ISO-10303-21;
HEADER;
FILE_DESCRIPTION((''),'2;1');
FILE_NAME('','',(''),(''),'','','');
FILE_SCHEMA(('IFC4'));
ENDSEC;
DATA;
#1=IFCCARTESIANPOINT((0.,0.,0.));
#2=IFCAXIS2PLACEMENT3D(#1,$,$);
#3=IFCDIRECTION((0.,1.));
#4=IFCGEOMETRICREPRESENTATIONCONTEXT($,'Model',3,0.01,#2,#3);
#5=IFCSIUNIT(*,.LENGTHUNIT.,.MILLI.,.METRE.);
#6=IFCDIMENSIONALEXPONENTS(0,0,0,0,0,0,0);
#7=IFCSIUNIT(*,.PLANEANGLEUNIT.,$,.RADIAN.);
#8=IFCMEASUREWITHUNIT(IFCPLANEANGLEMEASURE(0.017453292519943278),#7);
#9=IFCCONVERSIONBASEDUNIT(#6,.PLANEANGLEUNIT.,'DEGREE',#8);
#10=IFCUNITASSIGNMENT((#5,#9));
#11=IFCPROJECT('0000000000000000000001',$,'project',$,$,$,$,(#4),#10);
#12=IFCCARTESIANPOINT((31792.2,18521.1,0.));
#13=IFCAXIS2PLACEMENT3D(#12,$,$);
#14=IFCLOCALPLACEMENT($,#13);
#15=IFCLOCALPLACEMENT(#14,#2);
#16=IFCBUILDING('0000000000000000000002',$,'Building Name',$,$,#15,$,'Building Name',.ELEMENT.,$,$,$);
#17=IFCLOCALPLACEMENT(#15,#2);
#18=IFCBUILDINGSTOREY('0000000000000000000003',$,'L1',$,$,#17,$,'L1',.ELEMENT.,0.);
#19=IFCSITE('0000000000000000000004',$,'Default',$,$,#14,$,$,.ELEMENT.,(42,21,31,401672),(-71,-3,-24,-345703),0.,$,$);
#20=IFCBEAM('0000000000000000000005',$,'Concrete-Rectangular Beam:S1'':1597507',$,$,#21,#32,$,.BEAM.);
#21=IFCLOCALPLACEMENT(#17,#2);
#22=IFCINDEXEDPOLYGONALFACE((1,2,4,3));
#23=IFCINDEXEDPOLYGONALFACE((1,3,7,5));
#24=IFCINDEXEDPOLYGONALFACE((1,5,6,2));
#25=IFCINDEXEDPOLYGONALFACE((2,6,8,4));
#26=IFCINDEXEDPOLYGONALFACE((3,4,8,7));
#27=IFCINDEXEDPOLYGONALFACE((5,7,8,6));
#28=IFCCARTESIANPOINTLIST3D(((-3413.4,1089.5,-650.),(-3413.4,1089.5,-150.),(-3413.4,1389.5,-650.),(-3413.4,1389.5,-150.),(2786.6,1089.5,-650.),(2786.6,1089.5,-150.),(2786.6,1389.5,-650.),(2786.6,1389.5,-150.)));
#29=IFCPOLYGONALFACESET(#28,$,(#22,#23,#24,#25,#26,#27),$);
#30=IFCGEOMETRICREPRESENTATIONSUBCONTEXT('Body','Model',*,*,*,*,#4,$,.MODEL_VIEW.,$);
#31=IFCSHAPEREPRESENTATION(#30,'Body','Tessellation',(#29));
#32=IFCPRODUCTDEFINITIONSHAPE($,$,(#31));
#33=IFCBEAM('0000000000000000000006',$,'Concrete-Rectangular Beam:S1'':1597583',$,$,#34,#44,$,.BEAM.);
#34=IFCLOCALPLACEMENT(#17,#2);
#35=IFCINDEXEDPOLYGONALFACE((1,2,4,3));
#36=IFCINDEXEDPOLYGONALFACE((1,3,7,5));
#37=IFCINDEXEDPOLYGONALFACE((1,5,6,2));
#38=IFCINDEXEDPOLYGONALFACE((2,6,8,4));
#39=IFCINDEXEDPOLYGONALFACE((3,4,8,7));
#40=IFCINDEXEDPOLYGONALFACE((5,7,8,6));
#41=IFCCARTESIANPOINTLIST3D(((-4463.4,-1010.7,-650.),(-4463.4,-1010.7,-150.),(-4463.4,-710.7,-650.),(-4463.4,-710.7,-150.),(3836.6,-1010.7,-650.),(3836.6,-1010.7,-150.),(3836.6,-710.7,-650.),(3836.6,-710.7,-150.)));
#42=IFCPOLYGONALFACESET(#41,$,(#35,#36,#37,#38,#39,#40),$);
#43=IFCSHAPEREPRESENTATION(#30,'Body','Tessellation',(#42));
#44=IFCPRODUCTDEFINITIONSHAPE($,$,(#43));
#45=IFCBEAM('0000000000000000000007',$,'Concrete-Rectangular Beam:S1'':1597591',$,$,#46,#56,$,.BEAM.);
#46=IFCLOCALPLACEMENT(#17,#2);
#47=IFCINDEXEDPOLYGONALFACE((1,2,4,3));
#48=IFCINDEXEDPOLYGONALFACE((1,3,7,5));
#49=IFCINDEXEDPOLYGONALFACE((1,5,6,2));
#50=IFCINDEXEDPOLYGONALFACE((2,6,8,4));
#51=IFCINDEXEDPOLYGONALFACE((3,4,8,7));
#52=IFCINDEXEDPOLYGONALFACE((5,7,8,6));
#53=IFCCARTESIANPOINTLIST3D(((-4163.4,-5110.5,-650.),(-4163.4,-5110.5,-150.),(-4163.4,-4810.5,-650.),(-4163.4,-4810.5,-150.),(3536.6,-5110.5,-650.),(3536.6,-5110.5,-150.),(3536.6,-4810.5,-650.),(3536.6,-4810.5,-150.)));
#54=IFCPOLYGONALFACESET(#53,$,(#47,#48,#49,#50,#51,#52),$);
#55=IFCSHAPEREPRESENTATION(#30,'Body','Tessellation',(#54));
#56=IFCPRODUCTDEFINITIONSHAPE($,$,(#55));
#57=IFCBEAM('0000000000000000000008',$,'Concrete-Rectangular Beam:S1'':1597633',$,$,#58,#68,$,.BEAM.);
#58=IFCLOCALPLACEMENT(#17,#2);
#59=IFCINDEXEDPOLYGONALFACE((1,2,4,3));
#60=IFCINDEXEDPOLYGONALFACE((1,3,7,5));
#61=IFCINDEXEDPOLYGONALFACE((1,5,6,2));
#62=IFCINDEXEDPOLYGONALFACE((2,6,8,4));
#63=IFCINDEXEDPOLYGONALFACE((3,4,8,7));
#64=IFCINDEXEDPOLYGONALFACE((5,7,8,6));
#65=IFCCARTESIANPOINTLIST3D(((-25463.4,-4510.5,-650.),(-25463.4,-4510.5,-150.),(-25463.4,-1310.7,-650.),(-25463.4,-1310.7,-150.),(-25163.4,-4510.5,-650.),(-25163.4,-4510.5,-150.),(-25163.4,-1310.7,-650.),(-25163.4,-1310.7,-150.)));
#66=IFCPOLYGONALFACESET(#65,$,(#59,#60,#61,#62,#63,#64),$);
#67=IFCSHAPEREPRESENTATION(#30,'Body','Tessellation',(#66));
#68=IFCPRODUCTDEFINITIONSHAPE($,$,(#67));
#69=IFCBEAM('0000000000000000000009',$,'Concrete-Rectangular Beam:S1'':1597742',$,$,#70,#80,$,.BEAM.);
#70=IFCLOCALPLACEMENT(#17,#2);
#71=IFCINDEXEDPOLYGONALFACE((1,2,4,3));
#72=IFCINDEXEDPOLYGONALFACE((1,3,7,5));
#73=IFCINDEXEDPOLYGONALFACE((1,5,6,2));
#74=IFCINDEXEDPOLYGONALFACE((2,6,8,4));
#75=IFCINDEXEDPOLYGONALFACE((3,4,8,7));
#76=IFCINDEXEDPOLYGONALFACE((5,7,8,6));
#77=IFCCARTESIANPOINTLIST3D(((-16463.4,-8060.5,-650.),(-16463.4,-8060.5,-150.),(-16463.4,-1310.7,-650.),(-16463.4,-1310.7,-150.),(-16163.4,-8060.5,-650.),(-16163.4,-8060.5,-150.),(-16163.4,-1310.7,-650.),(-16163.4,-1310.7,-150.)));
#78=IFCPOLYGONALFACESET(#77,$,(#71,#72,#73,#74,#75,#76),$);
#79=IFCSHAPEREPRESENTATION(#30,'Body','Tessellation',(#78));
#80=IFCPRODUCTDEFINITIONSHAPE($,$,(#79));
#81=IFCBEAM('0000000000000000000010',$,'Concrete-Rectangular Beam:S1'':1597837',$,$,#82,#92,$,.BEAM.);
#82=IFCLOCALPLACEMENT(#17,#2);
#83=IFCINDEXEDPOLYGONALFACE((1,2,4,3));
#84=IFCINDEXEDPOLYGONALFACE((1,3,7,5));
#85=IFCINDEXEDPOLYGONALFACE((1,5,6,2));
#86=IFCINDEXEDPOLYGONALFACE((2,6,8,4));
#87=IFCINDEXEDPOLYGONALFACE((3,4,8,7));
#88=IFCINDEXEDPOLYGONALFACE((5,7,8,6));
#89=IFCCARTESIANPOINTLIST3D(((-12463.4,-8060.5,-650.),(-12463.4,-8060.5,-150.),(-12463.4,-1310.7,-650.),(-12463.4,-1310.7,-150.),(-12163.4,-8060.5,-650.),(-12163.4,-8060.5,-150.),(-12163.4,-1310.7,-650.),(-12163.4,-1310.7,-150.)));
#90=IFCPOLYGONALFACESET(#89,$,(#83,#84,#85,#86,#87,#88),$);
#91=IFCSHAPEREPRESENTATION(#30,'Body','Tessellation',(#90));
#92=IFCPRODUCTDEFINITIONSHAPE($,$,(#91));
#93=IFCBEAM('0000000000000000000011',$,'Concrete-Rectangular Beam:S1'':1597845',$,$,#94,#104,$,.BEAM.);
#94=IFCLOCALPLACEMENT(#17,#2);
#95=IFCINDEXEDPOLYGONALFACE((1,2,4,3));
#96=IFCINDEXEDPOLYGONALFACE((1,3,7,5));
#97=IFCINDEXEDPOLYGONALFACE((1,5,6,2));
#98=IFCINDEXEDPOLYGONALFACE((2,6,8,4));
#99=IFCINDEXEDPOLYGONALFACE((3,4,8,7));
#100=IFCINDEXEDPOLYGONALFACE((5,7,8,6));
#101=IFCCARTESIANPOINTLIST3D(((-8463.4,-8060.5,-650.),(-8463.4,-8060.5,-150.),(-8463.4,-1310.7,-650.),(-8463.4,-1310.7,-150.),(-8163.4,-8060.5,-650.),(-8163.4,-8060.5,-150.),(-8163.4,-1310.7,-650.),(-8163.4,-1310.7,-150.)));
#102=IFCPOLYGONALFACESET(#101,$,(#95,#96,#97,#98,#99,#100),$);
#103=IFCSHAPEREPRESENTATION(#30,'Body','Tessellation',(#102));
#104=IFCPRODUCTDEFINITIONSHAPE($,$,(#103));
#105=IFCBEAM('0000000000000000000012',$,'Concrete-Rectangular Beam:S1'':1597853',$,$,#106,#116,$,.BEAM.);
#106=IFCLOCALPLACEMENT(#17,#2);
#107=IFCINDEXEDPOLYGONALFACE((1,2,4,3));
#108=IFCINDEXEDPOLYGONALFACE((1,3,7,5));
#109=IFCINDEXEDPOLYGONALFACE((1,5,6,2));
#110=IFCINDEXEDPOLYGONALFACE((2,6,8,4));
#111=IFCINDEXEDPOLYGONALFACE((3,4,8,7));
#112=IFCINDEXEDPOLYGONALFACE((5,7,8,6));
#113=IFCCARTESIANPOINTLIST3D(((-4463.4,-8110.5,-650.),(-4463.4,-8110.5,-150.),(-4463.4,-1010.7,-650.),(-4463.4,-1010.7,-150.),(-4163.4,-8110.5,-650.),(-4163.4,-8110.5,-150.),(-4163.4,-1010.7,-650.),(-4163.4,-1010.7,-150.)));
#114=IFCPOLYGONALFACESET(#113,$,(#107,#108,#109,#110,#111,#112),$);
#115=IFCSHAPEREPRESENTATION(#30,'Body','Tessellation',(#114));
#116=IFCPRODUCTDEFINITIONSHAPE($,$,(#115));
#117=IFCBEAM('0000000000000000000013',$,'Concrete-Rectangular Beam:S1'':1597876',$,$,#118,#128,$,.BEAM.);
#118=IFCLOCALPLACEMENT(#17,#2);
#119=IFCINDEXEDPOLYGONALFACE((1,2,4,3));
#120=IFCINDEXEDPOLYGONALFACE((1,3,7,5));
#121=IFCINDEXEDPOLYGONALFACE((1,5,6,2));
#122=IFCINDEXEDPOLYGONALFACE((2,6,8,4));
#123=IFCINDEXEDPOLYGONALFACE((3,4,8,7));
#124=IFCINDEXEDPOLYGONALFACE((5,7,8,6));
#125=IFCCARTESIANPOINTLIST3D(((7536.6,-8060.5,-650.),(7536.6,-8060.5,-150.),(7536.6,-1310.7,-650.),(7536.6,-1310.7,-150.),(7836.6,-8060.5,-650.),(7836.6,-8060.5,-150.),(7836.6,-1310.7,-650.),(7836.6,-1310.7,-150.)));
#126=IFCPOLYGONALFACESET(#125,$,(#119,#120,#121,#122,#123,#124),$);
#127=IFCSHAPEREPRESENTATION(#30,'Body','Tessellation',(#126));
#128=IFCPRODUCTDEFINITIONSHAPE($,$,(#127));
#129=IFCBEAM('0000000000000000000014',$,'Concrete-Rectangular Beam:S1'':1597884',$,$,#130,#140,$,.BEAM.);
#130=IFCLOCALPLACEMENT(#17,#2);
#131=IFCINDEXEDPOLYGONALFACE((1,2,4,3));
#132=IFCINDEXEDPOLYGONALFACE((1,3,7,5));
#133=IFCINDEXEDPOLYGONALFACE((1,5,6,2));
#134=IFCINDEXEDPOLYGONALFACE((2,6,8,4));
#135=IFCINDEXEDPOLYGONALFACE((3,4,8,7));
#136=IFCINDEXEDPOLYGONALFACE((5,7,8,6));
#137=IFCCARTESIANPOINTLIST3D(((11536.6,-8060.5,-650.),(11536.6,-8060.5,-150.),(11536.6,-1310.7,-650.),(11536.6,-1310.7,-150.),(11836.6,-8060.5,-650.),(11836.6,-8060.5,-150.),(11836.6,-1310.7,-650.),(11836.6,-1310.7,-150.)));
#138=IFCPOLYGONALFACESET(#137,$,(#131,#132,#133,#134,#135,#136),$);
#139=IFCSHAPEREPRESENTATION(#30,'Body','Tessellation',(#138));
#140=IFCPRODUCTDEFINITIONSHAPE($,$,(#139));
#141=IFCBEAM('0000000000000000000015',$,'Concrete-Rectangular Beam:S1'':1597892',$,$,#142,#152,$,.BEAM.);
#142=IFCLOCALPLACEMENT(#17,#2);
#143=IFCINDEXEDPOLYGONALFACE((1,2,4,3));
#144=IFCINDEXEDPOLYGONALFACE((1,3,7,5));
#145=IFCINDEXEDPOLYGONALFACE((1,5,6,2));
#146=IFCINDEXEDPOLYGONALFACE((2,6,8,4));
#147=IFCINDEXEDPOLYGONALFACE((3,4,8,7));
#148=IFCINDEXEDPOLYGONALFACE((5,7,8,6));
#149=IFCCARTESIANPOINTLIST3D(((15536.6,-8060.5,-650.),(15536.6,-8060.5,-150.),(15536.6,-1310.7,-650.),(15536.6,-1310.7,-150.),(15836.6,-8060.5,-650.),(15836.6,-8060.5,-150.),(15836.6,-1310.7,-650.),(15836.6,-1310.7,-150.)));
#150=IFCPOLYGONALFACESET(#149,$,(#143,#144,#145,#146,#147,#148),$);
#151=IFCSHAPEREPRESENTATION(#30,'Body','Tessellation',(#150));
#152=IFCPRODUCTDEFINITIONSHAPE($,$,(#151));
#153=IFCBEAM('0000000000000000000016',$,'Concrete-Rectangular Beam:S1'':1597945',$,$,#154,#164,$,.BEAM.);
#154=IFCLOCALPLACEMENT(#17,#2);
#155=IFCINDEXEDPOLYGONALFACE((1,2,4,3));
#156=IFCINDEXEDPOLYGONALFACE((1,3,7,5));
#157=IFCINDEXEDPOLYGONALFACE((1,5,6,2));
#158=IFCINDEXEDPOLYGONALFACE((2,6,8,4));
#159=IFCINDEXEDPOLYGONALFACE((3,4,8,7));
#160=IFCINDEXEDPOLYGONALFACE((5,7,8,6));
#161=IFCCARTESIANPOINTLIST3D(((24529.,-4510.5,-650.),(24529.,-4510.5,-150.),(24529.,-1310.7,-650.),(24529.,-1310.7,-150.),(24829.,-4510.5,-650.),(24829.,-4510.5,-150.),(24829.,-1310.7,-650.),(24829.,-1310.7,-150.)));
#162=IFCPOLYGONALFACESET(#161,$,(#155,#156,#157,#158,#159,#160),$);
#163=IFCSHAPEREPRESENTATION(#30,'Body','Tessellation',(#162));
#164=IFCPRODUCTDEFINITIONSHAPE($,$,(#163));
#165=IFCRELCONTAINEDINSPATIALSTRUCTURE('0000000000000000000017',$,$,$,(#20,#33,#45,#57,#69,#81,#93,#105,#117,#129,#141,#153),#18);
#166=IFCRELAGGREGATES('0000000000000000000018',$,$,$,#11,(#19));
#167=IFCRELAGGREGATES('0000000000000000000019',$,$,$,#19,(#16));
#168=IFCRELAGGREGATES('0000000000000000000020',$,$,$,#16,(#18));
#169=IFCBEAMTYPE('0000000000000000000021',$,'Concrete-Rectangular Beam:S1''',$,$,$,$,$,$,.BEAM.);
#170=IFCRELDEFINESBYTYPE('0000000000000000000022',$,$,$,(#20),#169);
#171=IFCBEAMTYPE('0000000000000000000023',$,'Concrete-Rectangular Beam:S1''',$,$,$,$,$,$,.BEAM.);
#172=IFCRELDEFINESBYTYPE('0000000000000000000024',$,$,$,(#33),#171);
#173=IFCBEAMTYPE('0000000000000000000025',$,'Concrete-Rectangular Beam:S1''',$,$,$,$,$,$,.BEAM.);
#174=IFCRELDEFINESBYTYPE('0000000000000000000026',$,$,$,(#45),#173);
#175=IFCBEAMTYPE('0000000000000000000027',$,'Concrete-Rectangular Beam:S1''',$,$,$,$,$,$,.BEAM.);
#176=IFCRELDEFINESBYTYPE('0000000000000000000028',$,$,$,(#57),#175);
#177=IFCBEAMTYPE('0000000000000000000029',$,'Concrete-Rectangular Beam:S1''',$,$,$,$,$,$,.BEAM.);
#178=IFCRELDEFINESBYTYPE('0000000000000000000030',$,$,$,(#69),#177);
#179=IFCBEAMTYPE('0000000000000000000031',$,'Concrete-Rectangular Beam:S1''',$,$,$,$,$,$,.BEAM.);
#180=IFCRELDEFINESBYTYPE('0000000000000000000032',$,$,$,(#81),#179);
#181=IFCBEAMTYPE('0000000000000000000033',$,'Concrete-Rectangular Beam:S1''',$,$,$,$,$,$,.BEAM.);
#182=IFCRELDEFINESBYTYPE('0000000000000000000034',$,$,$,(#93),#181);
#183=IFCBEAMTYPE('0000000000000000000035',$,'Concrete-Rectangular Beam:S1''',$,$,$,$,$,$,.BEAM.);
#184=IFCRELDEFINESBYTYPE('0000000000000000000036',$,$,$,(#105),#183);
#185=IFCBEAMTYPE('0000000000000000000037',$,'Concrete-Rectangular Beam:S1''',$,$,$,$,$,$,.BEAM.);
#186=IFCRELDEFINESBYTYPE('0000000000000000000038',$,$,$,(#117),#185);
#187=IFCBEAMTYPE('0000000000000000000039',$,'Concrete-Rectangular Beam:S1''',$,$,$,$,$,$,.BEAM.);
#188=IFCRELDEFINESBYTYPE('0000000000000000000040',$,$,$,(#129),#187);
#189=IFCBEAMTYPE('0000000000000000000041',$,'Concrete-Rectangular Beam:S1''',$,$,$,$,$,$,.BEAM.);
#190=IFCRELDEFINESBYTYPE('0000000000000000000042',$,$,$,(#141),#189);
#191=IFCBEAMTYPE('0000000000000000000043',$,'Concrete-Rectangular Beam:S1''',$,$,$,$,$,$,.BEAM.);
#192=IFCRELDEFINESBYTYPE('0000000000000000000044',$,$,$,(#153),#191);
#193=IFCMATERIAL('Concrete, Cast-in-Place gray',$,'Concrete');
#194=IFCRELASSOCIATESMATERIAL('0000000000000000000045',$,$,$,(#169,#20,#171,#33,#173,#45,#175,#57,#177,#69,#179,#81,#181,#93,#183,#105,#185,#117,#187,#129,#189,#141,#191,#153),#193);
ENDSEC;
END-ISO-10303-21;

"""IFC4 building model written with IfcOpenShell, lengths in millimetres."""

from ifc_helpers import new_model, entity, si_unit, converted_unit, direction, frame, origin, place, context, subcontext, project, spatial, indexed_curve, outline, extrude, source, transform, mapped, material, type_object, type_shapes, element, save


model = new_model("IFC4")

# Units and contexts
model_context = context("Model", 3, precision=0.01, world=origin(), true_north=direction((0.0, 1.0)))
body_context = subcontext(model_context, "Body", "Model", "MODEL_VIEW")
ifc_project = project(units=[si_unit("LENGTHUNIT", "METRE", prefix="MILLI"), converted_unit("PLANEANGLEUNIT", "DEGREE", entity("IfcPlaneAngleMeasure", 0.017453292519943278), si_unit("PLANEANGLEUNIT", "RADIAN"), dimensions=[0, 0, 0, 0, 0, 0, 0])], contexts=[model_context])

# Site, building, storey
site_placement = place(None, frame((31792.2, 18521.1, 0.0)))
site = spatial("IfcSite", under=ifc_project, at=site_placement, Name="Default", CompositionType="ELEMENT", RefLatitude=(42, 21, 31, 401672), RefLongitude=(-71, -3, -24, -345703), RefElevation=0.0)
building_placement = place(site_placement, origin())
building = spatial("IfcBuilding", under=site, at=building_placement, Name="Building Name", LongName="Building Name", CompositionType="ELEMENT")
storey_placement = place(building_placement, origin())
storey = spatial("IfcBuildingStorey", under=building, at=storey_placement, Name="L1", LongName="L1", CompositionType="ELEMENT", Elevation=0.0)

# Beams
ifc_material = material(Name="Concrete, Cast-in-Place gray", Category="Concrete")
beam_type_1 = type_object("IfcBeamType", Name="Concrete-Rectangular Beam:S1'", PredefinedType="BEAM", material=ifc_material)
shared_shape_1 = source(origin(), body_context, "Body", "SweptSolid", [
    extrude(outline(indexed_curve([(-250.0, -150.0), (250.0, -150.0), (250.0, 150.0), (-250.0, 150.0), (-250.0, -150.0)], self_intersect=False)), frame((-3413.4, 1239.5, -400.0), z_axis=(1.0, 0.0, 0.0), x_axis=(0.0, 0.0, -1.0)), (0.0, 0.0, 1.0), 6200.0),
])
type_shapes(beam_type_1, [shared_shape_1])
beam_1_placement = place(storey_placement, origin())
element("IfcBeam", 1, at=beam_1_placement, inside=storey, type_object=beam_type_1, material=ifc_material, Name="Concrete-Rectangular Beam:S1':1597507", PredefinedType="BEAM", context=body_context, shape_type="MappedRepresentation", body=[
    mapped(shared_shape_1, transform((0.0, 0.0, 0.0), scale=1.0)),
])
beam_type_2 = type_object("IfcBeamType", Name="Concrete-Rectangular Beam:S1'", PredefinedType="BEAM", material=ifc_material)
shared_shape_2 = source(origin(), body_context, "Body", "SweptSolid", [
    extrude(outline(indexed_curve([(-250.0, -150.0), (250.0, -150.0), (250.0, 150.0), (-250.0, 150.0), (-250.0, -150.0)], self_intersect=False)), frame((-4463.4, -860.7, -400.0), z_axis=(1.0, 0.0, 0.0), x_axis=(0.0, 0.0, -1.0)), (0.0, 0.0, 1.0), 8300.0),
])
type_shapes(beam_type_2, [shared_shape_2])
beam_2_placement = place(storey_placement, origin())
element("IfcBeam", 2, at=beam_2_placement, inside=storey, type_object=beam_type_2, material=ifc_material, Name="Concrete-Rectangular Beam:S1':1597583", PredefinedType="BEAM", context=body_context, shape_type="MappedRepresentation", body=[
    mapped(shared_shape_2, transform((0.0, 0.0, 0.0), scale=1.0)),
])
beam_type_3 = type_object("IfcBeamType", Name="Concrete-Rectangular Beam:S1'", PredefinedType="BEAM", material=ifc_material)
shared_shape_3 = source(origin(), body_context, "Body", "SweptSolid", [
    extrude(outline(indexed_curve([(-250.0, -150.0), (250.0, -150.0), (250.0, 150.0), (-250.0, 150.0), (-250.0, -150.0)], self_intersect=False)), frame((-4163.4, -4960.5, -400.0), z_axis=(1.0, 0.0, 0.0), x_axis=(0.0, 0.0, -1.0)), (0.0, 0.0, 1.0), 7700.0),
])
type_shapes(beam_type_3, [shared_shape_3])
beam_3_placement = place(storey_placement, origin())
element("IfcBeam", 3, at=beam_3_placement, inside=storey, type_object=beam_type_3, material=ifc_material, Name="Concrete-Rectangular Beam:S1':1597591", PredefinedType="BEAM", context=body_context, shape_type="MappedRepresentation", body=[
    mapped(shared_shape_3, transform((0.0, 0.0, 0.0), scale=1.0)),
])
beam_type_4 = type_object("IfcBeamType", Name="Concrete-Rectangular Beam:S1'", PredefinedType="BEAM", material=ifc_material)
shared_shape_4 = source(origin(), body_context, "Body", "SweptSolid", [
    extrude(outline(indexed_curve([(-150.0, -250.0), (150.0, -250.0), (150.0, 250.0), (-150.0, 250.0), (-150.0, -250.0)], self_intersect=False)), frame((-25313.4, -4510.5, -400.0), z_axis=(0.0, 1.0, 0.0), x_axis=(-1.0, 0.0, 0.0)), (0.0, 0.0, 1.0), 3199.8),
])
type_shapes(beam_type_4, [shared_shape_4])
beam_4_placement = place(storey_placement, origin())
element("IfcBeam", 4, at=beam_4_placement, inside=storey, type_object=beam_type_4, material=ifc_material, Name="Concrete-Rectangular Beam:S1':1597633", PredefinedType="BEAM", context=body_context, shape_type="MappedRepresentation", body=[
    mapped(shared_shape_4, transform((0.0, 0.0, 0.0), scale=1.0)),
])
beam_type_5 = type_object("IfcBeamType", Name="Concrete-Rectangular Beam:S1'", PredefinedType="BEAM", material=ifc_material)
shared_shape_5 = source(origin(), body_context, "Body", "SweptSolid", [
    extrude(outline(indexed_curve([(-150.0, -250.0), (150.0, -250.0), (150.0, 250.0), (-150.0, 250.0), (-150.0, -250.0)], self_intersect=False)), frame((-16313.4, -8060.5, -400.0), z_axis=(0.0, 1.0, 0.0), x_axis=(-1.0, 0.0, 0.0)), (0.0, 0.0, 1.0), 6749.8),
])
type_shapes(beam_type_5, [shared_shape_5])
beam_5_placement = place(storey_placement, origin())
element("IfcBeam", 5, at=beam_5_placement, inside=storey, type_object=beam_type_5, material=ifc_material, Name="Concrete-Rectangular Beam:S1':1597742", PredefinedType="BEAM", context=body_context, shape_type="MappedRepresentation", body=[
    mapped(shared_shape_5, transform((0.0, 0.0, 0.0), scale=1.0)),
])
beam_type_6 = type_object("IfcBeamType", Name="Concrete-Rectangular Beam:S1'", PredefinedType="BEAM", material=ifc_material)
shared_shape_6 = source(origin(), body_context, "Body", "SweptSolid", [
    extrude(outline(indexed_curve([(-150.0, -250.0), (150.0, -250.0), (150.0, 250.0), (-150.0, 250.0), (-150.0, -250.0)], self_intersect=False)), frame((-12313.4, -8060.5, -400.0), z_axis=(0.0, 1.0, 0.0), x_axis=(-1.0, 0.0, 0.0)), (0.0, 0.0, 1.0), 6749.8),
])
type_shapes(beam_type_6, [shared_shape_6])
beam_6_placement = place(storey_placement, origin())
element("IfcBeam", 6, at=beam_6_placement, inside=storey, type_object=beam_type_6, material=ifc_material, Name="Concrete-Rectangular Beam:S1':1597837", PredefinedType="BEAM", context=body_context, shape_type="MappedRepresentation", body=[
    mapped(shared_shape_6, transform((0.0, 0.0, 0.0), scale=1.0)),
])
beam_type_7 = type_object("IfcBeamType", Name="Concrete-Rectangular Beam:S1'", PredefinedType="BEAM", material=ifc_material)
shared_shape_7 = source(origin(), body_context, "Body", "SweptSolid", [
    extrude(outline(indexed_curve([(-150.0, -250.0), (150.0, -250.0), (150.0, 250.0), (-150.0, 250.0), (-150.0, -250.0)], self_intersect=False)), frame((-8313.4, -8060.5, -400.0), z_axis=(0.0, 1.0, 0.0), x_axis=(-1.0, 0.0, 0.0)), (0.0, 0.0, 1.0), 6749.8),
])
type_shapes(beam_type_7, [shared_shape_7])
beam_7_placement = place(storey_placement, origin())
element("IfcBeam", 7, at=beam_7_placement, inside=storey, type_object=beam_type_7, material=ifc_material, Name="Concrete-Rectangular Beam:S1':1597845", PredefinedType="BEAM", context=body_context, shape_type="MappedRepresentation", body=[
    mapped(shared_shape_7, transform((0.0, 0.0, 0.0), scale=1.0)),
])
beam_type_8 = type_object("IfcBeamType", Name="Concrete-Rectangular Beam:S1'", PredefinedType="BEAM", material=ifc_material)
shared_shape_8 = source(origin(), body_context, "Body", "SweptSolid", [
    extrude(outline(indexed_curve([(-150.0, -250.0), (150.0, -250.0), (150.0, 250.0), (-150.0, 250.0), (-150.0, -250.0)], self_intersect=False)), frame((-4313.4, -8110.5, -400.0), z_axis=(0.0, 1.0, 0.0), x_axis=(-1.0, 0.0, 0.0)), (0.0, 0.0, 1.0), 7099.8),
])
type_shapes(beam_type_8, [shared_shape_8])
beam_8_placement = place(storey_placement, origin())
element("IfcBeam", 8, at=beam_8_placement, inside=storey, type_object=beam_type_8, material=ifc_material, Name="Concrete-Rectangular Beam:S1':1597853", PredefinedType="BEAM", context=body_context, shape_type="MappedRepresentation", body=[
    mapped(shared_shape_8, transform((0.0, 0.0, 0.0), scale=1.0)),
])
beam_type_9 = type_object("IfcBeamType", Name="Concrete-Rectangular Beam:S1'", PredefinedType="BEAM", material=ifc_material)
shared_shape_9 = source(origin(), body_context, "Body", "SweptSolid", [
    extrude(outline(indexed_curve([(-150.0, -250.0), (150.0, -250.0), (150.0, 250.0), (-150.0, 250.0), (-150.0, -250.0)], self_intersect=False)), frame((7686.6, -8060.5, -400.0), z_axis=(0.0, 1.0, 0.0), x_axis=(-1.0, 0.0, 0.0)), (0.0, 0.0, 1.0), 6749.8),
])
type_shapes(beam_type_9, [shared_shape_9])
beam_9_placement = place(storey_placement, origin())
element("IfcBeam", 9, at=beam_9_placement, inside=storey, type_object=beam_type_9, material=ifc_material, Name="Concrete-Rectangular Beam:S1':1597876", PredefinedType="BEAM", context=body_context, shape_type="MappedRepresentation", body=[
    mapped(shared_shape_9, transform((0.0, 0.0, 0.0), scale=1.0)),
])
beam_type_10 = type_object("IfcBeamType", Name="Concrete-Rectangular Beam:S1'", PredefinedType="BEAM", material=ifc_material)
shared_shape_10 = source(origin(), body_context, "Body", "SweptSolid", [
    extrude(outline(indexed_curve([(-150.0, -250.0), (150.0, -250.0), (150.0, 250.0), (-150.0, 250.0), (-150.0, -250.0)], self_intersect=False)), frame((11686.6, -8060.5, -400.0), z_axis=(0.0, 1.0, 0.0), x_axis=(-1.0, 0.0, 0.0)), (0.0, 0.0, 1.0), 6749.8),
])
type_shapes(beam_type_10, [shared_shape_10])
beam_10_placement = place(storey_placement, origin())
element("IfcBeam", 10, at=beam_10_placement, inside=storey, type_object=beam_type_10, material=ifc_material, Name="Concrete-Rectangular Beam:S1':1597884", PredefinedType="BEAM", context=body_context, shape_type="MappedRepresentation", body=[
    mapped(shared_shape_10, transform((0.0, 0.0, 0.0), scale=1.0)),
])
beam_type_11 = type_object("IfcBeamType", Name="Concrete-Rectangular Beam:S1'", PredefinedType="BEAM", material=ifc_material)
shared_shape_11 = source(origin(), body_context, "Body", "SweptSolid", [
    extrude(outline(indexed_curve([(-150.0, -250.0), (150.0, -250.0), (150.0, 250.0), (-150.0, 250.0), (-150.0, -250.0)], self_intersect=False)), frame((15686.6, -8060.5, -400.0), z_axis=(0.0, 1.0, 0.0), x_axis=(-1.0, 0.0, 0.0)), (0.0, 0.0, 1.0), 6749.8),
])
type_shapes(beam_type_11, [shared_shape_11])
beam_11_placement = place(storey_placement, origin())
element("IfcBeam", 11, at=beam_11_placement, inside=storey, type_object=beam_type_11, material=ifc_material, Name="Concrete-Rectangular Beam:S1':1597892", PredefinedType="BEAM", context=body_context, shape_type="MappedRepresentation", body=[
    mapped(shared_shape_11, transform((0.0, 0.0, 0.0), scale=1.0)),
])
beam_type_12 = type_object("IfcBeamType", Name="Concrete-Rectangular Beam:S1'", PredefinedType="BEAM", material=ifc_material)
shared_shape_12 = source(origin(), body_context, "Body", "SweptSolid", [
    extrude(outline(indexed_curve([(-150.0, -250.0), (150.0, -250.0), (150.0, 250.0), (-150.0, 250.0), (-150.0, -250.0)], self_intersect=False)), frame((24679.0, -4510.5, -400.0), z_axis=(0.0, 1.0, 0.0), x_axis=(-1.0, 0.0, 0.0)), (0.0, 0.0, 1.0), 3199.8),
])
type_shapes(beam_type_12, [shared_shape_12])
beam_12_placement = place(storey_placement, origin())
element("IfcBeam", 12, at=beam_12_placement, inside=storey, type_object=beam_type_12, material=ifc_material, Name="Concrete-Rectangular Beam:S1':1597945", PredefinedType="BEAM", context=body_context, shape_type="MappedRepresentation", body=[
    mapped(shared_shape_12, transform((0.0, 0.0, 0.0), scale=1.0)),
])

save(model, "model.ifc")
